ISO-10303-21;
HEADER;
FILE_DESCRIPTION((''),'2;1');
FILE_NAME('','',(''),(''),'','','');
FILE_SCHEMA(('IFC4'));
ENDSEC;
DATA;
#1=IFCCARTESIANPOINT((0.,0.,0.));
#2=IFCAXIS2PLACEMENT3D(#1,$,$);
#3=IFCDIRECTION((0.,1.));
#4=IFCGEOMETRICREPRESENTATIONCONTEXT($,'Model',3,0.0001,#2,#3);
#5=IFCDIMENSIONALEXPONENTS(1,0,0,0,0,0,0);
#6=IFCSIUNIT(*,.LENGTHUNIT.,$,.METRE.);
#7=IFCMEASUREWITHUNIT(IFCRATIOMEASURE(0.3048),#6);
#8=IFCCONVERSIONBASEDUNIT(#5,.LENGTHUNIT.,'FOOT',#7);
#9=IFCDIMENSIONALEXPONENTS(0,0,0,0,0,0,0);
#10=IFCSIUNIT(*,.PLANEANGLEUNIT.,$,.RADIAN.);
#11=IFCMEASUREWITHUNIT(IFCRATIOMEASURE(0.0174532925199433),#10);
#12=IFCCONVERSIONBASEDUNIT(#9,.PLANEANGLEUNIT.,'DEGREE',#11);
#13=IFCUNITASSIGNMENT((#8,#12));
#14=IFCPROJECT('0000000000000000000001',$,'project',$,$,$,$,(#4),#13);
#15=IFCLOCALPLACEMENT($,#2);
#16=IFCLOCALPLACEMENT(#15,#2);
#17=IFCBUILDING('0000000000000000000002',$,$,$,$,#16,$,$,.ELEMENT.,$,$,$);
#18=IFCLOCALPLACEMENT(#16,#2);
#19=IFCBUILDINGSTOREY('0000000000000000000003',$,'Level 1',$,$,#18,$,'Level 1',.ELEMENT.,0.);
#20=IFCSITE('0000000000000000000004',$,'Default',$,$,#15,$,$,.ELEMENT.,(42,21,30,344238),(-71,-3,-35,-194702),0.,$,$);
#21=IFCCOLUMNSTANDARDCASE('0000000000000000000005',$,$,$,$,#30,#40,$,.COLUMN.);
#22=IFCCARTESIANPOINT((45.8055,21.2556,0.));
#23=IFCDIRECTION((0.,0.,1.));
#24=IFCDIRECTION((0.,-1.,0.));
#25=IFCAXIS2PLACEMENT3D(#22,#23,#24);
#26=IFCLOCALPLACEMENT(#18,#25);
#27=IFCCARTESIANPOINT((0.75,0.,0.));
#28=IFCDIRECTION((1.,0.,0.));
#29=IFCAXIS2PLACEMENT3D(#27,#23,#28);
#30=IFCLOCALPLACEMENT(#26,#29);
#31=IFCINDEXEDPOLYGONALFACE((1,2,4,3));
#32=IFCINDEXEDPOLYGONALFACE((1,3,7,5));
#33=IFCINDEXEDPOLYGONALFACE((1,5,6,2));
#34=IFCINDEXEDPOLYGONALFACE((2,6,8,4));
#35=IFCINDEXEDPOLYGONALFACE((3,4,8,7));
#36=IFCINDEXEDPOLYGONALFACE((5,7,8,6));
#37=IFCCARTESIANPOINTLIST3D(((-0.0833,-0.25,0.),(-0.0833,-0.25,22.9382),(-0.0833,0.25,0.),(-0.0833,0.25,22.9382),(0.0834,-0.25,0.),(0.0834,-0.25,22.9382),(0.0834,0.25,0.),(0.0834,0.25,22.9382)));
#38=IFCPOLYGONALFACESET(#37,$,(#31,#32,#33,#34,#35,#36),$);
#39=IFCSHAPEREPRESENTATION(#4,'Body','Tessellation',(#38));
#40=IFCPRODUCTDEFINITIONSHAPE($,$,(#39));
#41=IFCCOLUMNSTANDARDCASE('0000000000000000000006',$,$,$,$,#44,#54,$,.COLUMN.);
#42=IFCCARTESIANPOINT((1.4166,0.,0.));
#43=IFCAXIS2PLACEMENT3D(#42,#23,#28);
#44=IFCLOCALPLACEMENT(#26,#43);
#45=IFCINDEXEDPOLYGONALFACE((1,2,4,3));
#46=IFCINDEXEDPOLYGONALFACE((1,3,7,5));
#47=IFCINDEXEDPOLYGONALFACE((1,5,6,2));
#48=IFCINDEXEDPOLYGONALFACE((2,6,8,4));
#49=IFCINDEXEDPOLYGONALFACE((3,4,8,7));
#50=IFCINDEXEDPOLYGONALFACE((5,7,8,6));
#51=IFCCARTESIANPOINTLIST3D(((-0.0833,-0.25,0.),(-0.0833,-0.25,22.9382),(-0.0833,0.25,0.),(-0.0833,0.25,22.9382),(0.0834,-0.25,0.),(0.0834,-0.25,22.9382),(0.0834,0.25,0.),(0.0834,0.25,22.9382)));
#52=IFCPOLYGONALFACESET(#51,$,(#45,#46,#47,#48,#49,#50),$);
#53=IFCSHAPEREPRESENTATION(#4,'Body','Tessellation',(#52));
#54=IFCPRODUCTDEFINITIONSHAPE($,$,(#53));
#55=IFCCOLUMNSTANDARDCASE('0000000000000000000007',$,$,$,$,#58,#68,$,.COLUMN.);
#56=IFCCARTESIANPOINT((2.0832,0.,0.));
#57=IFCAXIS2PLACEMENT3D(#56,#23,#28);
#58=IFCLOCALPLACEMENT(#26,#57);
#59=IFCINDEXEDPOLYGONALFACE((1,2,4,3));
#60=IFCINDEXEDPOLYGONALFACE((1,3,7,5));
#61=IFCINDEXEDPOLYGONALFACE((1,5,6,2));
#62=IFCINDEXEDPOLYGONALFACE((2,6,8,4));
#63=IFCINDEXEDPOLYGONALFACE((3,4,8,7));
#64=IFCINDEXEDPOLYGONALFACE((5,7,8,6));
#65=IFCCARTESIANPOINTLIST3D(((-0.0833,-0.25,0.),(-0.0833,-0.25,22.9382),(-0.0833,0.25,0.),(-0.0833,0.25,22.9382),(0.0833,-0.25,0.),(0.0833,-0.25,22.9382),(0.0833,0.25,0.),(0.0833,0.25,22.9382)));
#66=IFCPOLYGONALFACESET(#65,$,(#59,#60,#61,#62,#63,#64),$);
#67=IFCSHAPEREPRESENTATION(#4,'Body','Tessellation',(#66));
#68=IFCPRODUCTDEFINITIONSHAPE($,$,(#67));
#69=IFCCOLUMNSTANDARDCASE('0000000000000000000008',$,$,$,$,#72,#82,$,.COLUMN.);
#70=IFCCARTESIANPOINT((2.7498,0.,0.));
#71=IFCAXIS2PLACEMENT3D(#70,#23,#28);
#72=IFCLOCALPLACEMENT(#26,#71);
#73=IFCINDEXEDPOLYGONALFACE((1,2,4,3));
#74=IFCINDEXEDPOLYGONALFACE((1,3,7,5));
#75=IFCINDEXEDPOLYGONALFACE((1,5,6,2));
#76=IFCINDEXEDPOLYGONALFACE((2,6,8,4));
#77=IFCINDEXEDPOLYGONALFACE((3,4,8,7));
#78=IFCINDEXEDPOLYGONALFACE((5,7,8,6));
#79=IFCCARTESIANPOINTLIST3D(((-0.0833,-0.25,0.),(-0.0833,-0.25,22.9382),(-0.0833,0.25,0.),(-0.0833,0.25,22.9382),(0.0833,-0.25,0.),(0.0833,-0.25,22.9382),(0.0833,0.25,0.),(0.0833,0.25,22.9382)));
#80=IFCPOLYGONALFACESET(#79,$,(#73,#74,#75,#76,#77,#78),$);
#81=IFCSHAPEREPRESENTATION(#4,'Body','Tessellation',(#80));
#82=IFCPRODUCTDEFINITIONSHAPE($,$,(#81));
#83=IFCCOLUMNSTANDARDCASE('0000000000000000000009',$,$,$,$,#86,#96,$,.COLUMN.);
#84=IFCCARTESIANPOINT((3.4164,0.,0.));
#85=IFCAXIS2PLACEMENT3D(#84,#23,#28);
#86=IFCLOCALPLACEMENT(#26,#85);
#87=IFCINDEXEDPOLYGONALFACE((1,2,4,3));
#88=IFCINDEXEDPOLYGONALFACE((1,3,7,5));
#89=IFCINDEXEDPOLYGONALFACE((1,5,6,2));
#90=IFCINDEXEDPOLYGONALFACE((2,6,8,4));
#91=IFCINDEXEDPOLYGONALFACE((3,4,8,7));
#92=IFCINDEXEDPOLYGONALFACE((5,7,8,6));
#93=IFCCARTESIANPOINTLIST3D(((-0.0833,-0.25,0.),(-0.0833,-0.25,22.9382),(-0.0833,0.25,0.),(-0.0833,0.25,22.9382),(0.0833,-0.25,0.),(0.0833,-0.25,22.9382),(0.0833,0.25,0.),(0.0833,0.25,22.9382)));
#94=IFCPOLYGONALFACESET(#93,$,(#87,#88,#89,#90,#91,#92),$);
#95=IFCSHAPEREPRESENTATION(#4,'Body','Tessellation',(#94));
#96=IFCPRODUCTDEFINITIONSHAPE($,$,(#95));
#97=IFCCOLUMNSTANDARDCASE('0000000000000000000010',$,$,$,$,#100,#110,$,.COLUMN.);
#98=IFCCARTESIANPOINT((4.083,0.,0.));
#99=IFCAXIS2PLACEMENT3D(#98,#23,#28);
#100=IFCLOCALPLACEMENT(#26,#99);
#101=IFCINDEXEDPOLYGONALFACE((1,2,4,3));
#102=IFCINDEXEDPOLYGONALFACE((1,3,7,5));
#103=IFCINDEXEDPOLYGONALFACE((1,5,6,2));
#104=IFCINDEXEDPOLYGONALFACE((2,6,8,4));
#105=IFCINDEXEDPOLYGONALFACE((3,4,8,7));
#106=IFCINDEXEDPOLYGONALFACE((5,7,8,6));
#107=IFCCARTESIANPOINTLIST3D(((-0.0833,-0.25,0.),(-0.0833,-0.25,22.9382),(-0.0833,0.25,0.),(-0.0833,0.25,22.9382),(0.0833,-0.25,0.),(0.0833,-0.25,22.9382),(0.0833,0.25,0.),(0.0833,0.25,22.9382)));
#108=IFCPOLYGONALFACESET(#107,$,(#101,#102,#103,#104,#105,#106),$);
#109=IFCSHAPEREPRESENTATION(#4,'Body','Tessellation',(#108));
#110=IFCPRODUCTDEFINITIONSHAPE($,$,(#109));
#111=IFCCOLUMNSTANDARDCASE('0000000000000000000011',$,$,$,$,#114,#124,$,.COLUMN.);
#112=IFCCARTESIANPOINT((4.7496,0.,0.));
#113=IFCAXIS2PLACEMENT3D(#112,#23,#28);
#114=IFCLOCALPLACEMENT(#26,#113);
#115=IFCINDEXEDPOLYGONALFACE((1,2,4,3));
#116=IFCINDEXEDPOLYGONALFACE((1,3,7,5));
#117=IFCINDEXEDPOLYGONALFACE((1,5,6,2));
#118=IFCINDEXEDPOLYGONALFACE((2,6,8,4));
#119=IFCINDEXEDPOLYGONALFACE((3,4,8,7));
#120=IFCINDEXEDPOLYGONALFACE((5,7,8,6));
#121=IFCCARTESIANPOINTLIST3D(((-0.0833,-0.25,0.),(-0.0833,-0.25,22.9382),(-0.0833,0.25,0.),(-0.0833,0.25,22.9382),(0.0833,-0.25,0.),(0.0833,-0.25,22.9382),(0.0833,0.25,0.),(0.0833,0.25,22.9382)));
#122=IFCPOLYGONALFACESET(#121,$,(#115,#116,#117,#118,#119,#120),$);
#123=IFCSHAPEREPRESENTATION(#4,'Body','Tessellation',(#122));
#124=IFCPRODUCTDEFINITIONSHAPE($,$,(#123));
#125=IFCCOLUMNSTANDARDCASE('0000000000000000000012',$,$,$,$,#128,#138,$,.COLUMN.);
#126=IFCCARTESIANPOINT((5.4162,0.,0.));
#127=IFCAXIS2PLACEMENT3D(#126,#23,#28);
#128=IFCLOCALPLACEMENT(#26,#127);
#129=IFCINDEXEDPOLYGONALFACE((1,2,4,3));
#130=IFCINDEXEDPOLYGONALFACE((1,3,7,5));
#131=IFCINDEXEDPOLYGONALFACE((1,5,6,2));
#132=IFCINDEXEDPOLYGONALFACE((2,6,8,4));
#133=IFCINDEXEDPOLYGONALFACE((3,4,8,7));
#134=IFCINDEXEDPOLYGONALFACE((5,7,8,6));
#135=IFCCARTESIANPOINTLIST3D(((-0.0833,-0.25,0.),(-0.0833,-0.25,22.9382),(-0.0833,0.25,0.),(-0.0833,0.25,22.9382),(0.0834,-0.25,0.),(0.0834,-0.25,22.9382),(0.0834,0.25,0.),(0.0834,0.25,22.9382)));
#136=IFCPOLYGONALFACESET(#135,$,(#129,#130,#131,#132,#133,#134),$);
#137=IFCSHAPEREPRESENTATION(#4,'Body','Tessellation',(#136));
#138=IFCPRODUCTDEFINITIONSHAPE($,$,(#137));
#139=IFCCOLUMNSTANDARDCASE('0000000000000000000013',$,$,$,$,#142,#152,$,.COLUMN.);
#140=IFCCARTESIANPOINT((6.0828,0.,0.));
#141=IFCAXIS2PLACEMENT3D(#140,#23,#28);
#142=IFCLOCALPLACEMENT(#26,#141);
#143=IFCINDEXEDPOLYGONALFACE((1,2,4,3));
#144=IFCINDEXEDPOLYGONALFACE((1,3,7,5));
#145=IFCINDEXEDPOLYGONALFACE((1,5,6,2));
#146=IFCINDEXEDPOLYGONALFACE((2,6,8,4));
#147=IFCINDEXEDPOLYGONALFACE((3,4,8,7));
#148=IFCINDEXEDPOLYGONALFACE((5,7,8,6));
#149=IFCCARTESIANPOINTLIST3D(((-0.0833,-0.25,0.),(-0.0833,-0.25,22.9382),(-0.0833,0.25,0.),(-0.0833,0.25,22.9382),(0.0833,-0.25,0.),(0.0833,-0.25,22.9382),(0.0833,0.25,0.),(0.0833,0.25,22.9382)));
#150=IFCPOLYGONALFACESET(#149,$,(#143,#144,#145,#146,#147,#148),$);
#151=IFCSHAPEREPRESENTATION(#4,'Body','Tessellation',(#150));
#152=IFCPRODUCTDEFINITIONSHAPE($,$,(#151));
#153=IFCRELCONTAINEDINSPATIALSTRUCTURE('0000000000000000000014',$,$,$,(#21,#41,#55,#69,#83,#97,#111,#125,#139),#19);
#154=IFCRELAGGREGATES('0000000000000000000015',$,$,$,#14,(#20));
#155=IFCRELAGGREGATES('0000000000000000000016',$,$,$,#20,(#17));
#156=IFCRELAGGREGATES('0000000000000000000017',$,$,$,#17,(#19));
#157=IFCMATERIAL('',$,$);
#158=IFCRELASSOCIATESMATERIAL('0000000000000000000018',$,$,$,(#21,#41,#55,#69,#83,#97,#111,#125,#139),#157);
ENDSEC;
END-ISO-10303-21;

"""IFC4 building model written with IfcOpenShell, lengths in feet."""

from ifc_helpers import new_model, entity, si_unit, converted_unit, direction, frame, origin, place, context, project, spatial, rectangle, extrude, material, element, save


model = new_model("IFC4")

# Units and contexts
model_context = context("Model", 3, precision=0.0001, world=origin(), true_north=direction((0.0, 1.0)))
ifc_project = project(units=[converted_unit("LENGTHUNIT", "FOOT", entity("IfcRatioMeasure", 0.3048), si_unit("LENGTHUNIT", "METRE"), dimensions=[1, 0, 0, 0, 0, 0, 0]), converted_unit("PLANEANGLEUNIT", "DEGREE", entity("IfcRatioMeasure", 0.0174532925199433), si_unit("PLANEANGLEUNIT", "RADIAN"), dimensions=[0, 0, 0, 0, 0, 0, 0])], contexts=[model_context])

# Site, building, storey
site_placement = place(None, origin())
site = spatial("IfcSite", under=ifc_project, at=site_placement, Name="Default", CompositionType="ELEMENT", RefLatitude=(42, 21, 30, 344238), RefLongitude=(-71, -3, -35, -194702), RefElevation=0.0)
building_placement = place(site_placement, origin())
building = spatial("IfcBuilding", under=site, at=building_placement, CompositionType="ELEMENT")
storey_placement = place(building_placement, origin())
storey = spatial("IfcBuildingStorey", under=building, at=storey_placement, Name="Level 1", LongName="Level 1", CompositionType="ELEMENT", Elevation=0.0)

# Columns
ifc_material_1 = material(Name="")
wall_1_placement = place(storey_placement, frame((45.8055, 21.2556, 0.0), z_axis=(0.0, 0.0, 1.0), x_axis=(0.0, -1.0, 0.0)))
for number, where, z_axis, x_axis in (
    (1, (0.75, 0.0, 0.0), (0.0, 0.0, 1.0), (1.0, 0.0, 0.0)),
    (2, (1.4166, 0.0, 0.0), (0.0, 0.0, 1.0), (1.0, 0.0, 0.0)),
    (3, (2.0832, 0.0, 0.0), (0.0, 0.0, 1.0), (1.0, 0.0, 0.0)),
    (4, (2.7498, 0.0, 0.0), (0.0, 0.0, 1.0), (1.0, 0.0, 0.0)),
    (5, (3.4164, 0.0, 0.0), (0.0, 0.0, 1.0), (1.0, 0.0, 0.0)),
    (6, (4.083, 0.0, 0.0), (0.0, 0.0, 1.0), (1.0, 0.0, 0.0)),
    (7, (4.7496, 0.0, 0.0), (0.0, 0.0, 1.0), (1.0, 0.0, 0.0)),
    (8, (5.4162, 0.0, 0.0), (0.0, 0.0, 1.0), (1.0, 0.0, 0.0)),
    (9, (6.0828, 0.0, 0.0), (0.0, 0.0, 1.0), (1.0, 0.0, 0.0)),
):
    element("IfcColumnStandardCase", number, at=place(wall_1_placement, frame(where, z_axis=z_axis, x_axis=x_axis)), inside=storey, material=ifc_material_1, PredefinedType="COLUMN", context=model_context, shape_type="SweptSolid", body=[
        extrude(rectangle(XDim=0.1667, YDim=0.5), origin(), (0.0, 0.0, 1.0), 22.9382),
    ])

save(model, "model.ifc")
